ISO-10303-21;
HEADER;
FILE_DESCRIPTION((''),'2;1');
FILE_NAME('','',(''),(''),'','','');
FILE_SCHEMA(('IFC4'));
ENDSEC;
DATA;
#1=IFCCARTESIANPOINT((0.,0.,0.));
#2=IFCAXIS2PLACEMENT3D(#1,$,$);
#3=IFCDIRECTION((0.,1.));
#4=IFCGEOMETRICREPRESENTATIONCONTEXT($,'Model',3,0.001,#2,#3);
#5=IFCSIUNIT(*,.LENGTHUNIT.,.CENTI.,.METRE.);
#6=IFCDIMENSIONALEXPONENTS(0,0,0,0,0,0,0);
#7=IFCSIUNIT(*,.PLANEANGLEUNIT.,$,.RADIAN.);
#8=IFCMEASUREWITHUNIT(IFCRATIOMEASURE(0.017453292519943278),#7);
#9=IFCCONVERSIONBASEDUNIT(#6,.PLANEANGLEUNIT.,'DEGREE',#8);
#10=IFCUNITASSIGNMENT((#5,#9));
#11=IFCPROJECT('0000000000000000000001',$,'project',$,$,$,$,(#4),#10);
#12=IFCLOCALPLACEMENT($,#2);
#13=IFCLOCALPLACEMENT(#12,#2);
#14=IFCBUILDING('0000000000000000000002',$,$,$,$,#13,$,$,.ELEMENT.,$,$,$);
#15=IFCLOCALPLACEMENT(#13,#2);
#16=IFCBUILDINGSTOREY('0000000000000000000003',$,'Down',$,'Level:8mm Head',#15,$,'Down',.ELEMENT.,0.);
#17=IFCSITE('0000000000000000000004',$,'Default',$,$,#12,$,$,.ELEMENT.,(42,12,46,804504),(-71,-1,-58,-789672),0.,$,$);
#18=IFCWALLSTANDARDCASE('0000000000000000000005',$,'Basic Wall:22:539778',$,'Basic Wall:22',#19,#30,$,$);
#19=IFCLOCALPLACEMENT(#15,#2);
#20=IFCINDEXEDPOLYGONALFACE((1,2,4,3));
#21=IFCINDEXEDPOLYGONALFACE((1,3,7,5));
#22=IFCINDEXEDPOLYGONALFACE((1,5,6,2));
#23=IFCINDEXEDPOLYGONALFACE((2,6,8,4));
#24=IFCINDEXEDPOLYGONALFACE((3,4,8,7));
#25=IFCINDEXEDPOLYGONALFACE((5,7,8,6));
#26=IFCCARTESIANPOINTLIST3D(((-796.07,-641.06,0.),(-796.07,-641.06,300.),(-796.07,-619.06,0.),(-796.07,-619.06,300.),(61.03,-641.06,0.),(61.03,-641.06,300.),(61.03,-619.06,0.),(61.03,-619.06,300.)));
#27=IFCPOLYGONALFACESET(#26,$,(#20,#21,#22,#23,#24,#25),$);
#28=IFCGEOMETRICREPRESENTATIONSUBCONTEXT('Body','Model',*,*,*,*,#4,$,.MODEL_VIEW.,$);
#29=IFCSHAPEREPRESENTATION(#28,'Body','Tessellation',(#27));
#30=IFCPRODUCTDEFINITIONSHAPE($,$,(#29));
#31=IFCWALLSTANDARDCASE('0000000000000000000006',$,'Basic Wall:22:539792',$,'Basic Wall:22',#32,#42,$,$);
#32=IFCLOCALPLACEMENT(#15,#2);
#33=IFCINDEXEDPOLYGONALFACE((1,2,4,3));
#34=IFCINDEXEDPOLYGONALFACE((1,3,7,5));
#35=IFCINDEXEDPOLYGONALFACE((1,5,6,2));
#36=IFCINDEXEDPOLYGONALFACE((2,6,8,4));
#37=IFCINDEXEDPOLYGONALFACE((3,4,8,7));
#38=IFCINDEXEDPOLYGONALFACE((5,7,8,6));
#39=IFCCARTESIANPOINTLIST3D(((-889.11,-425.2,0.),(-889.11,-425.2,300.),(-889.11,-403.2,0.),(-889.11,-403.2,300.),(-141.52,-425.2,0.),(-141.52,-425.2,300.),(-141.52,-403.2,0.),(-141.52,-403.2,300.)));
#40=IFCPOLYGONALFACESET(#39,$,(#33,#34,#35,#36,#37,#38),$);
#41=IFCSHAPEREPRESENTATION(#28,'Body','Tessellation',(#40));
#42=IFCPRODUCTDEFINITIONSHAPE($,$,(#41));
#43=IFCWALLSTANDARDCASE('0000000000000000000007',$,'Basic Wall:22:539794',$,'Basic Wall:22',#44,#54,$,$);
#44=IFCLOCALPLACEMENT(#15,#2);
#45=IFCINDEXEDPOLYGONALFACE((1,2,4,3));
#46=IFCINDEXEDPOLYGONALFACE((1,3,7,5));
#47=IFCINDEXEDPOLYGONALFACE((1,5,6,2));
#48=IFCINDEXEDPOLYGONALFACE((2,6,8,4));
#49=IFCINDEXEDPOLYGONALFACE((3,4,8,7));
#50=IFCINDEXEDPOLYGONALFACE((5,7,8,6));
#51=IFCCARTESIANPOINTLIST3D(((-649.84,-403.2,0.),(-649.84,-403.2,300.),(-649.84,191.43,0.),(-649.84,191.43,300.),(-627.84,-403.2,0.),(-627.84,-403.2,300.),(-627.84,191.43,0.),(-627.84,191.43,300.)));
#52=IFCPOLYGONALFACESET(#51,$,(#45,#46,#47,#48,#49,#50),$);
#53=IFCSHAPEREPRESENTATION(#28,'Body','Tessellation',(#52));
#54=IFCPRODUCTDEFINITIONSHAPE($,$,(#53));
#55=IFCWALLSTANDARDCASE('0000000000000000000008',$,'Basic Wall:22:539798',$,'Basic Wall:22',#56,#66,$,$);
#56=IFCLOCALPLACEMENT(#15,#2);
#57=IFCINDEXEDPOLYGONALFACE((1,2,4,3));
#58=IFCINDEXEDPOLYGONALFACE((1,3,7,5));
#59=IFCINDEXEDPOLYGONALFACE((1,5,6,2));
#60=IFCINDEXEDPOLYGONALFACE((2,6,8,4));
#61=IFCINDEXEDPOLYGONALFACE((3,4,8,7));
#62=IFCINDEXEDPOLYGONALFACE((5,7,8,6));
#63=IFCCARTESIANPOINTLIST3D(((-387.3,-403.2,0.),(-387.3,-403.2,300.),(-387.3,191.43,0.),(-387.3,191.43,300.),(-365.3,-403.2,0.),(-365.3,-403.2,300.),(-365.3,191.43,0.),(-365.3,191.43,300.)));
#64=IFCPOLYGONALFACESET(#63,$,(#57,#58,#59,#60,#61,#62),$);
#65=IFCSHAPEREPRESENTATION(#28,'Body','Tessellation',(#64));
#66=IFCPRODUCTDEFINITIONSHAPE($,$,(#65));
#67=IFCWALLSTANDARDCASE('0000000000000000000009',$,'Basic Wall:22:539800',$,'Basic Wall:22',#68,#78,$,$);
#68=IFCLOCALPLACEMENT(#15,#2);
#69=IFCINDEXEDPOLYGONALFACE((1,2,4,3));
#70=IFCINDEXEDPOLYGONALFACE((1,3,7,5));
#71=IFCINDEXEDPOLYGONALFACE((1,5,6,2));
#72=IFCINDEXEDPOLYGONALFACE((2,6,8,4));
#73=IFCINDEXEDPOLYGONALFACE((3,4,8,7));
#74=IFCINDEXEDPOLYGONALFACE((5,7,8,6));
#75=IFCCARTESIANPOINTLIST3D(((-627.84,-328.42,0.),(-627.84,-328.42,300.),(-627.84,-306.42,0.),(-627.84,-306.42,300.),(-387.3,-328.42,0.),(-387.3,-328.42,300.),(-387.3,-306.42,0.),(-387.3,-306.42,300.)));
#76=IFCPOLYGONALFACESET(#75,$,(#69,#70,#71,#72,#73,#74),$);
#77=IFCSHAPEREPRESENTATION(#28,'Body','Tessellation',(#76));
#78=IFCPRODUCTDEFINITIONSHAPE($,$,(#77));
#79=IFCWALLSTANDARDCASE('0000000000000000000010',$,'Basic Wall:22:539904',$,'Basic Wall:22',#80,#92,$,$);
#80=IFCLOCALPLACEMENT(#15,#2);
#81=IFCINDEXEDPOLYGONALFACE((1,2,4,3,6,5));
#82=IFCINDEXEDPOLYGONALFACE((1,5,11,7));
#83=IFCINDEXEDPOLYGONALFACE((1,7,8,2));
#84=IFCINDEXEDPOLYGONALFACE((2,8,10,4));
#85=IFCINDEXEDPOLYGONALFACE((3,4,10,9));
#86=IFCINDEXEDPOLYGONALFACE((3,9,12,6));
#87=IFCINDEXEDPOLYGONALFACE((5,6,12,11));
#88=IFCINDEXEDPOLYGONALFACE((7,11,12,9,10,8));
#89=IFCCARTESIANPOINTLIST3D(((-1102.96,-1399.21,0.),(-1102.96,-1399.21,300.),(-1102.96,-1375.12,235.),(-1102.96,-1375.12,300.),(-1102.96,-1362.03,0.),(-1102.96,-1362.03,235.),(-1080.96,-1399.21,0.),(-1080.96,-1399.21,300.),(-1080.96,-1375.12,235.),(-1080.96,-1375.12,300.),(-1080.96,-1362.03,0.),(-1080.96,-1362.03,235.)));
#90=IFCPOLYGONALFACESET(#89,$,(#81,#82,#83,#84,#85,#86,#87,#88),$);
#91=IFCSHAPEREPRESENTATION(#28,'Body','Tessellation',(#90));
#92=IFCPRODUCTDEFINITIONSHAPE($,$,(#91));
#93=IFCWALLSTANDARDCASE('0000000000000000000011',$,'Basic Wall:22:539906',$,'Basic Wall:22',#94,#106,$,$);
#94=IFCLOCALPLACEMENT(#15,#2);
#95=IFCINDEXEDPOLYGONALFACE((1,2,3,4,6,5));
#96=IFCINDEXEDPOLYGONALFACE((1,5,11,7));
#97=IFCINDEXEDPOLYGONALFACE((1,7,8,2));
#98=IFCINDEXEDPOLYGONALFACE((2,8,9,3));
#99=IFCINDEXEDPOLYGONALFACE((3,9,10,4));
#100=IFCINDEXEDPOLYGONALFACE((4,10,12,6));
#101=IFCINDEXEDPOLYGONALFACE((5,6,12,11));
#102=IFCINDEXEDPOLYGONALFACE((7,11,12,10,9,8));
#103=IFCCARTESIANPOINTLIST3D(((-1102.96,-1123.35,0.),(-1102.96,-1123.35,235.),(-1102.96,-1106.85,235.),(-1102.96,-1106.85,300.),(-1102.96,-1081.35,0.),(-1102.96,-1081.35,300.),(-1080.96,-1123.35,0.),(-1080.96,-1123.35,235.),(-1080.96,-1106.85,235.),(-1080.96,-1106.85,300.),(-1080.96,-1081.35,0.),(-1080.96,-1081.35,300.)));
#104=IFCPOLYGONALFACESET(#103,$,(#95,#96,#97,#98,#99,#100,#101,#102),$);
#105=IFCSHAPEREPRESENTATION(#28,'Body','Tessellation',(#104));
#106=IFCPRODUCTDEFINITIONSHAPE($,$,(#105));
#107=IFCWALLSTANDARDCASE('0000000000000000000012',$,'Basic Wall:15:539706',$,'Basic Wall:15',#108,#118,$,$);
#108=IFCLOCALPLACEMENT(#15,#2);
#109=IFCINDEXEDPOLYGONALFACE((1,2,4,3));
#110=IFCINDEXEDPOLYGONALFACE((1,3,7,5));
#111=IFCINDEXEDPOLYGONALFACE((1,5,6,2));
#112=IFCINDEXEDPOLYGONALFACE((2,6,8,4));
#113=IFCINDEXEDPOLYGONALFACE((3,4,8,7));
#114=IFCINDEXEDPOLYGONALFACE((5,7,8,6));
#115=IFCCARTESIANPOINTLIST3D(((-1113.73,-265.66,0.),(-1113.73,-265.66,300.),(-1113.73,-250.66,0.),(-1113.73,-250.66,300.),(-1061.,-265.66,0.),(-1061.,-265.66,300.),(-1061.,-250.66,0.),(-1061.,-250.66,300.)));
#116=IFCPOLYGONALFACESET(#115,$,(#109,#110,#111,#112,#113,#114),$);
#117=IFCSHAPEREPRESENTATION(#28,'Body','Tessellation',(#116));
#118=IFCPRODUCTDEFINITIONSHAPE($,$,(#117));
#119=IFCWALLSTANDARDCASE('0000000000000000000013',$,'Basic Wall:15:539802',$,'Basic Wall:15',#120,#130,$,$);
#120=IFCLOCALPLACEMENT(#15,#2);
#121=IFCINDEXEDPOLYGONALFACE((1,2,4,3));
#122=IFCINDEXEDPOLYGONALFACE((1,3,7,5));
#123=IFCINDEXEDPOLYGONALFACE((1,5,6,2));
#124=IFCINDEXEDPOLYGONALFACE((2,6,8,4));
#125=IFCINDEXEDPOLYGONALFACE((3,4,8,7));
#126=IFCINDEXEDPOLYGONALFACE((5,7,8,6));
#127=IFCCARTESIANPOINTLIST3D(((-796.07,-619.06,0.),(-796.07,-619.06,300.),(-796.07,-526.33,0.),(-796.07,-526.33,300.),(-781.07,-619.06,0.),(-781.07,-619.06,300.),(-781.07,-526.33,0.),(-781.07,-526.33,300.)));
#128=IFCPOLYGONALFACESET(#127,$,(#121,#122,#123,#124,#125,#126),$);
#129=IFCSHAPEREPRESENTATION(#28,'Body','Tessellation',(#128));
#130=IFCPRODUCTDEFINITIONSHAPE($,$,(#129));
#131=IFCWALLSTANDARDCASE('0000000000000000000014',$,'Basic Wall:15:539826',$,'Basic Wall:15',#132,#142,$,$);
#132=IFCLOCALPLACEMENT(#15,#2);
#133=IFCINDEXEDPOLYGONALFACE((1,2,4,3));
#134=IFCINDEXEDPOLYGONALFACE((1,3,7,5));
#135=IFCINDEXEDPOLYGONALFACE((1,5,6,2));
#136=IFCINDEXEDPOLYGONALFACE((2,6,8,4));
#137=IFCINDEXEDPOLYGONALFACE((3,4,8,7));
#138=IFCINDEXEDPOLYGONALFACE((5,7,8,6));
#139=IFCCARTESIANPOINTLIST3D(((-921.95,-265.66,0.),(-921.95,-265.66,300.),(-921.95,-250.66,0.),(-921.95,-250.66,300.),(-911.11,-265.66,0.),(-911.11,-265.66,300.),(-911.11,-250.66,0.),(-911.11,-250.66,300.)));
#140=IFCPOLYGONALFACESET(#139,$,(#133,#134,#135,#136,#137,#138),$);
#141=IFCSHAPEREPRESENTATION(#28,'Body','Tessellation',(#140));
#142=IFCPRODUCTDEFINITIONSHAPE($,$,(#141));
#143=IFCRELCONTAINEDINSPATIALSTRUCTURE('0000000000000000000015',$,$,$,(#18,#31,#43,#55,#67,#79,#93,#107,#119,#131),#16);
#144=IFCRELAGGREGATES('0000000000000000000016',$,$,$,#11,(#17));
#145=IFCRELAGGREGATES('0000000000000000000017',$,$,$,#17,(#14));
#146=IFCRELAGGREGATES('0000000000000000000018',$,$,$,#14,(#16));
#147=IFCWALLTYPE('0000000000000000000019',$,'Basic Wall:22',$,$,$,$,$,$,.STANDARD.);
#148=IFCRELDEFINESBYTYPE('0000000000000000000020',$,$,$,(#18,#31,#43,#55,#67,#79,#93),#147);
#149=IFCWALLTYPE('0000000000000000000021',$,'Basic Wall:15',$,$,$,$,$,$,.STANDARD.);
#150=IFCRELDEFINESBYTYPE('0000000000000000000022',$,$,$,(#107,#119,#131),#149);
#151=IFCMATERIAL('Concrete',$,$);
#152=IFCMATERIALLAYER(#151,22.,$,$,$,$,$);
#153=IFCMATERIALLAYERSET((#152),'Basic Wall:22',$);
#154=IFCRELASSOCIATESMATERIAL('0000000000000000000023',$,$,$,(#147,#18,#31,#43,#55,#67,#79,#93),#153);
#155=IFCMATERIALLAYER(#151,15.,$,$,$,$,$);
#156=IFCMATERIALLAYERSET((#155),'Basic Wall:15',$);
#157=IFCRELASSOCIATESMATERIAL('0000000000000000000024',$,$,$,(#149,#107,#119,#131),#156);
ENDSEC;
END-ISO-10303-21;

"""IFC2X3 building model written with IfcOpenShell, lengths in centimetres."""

from ifc_helpers import new_model, entity, si_unit, converted_unit, direction, frame, frame_2d, origin, place, context, subcontext, project, spatial, polyline, rectangle, extrude, clip, bounded_halfspace, material, layer, layer_set, layer_usage, type_object, element, save


model = new_model("IFC2X3")

# Units and contexts
model_context = context("Model", 3, precision=0.001, world=origin(), true_north=direction((0.0, 1.0)))
body_context = subcontext(model_context, "Body", "Model", "MODEL_VIEW")
ifc_project = project(units=[si_unit("LENGTHUNIT", "METRE", prefix="CENTI"), converted_unit("PLANEANGLEUNIT", "DEGREE", entity("IfcRatioMeasure", 0.017453292519943278), si_unit("PLANEANGLEUNIT", "RADIAN"), dimensions=[0, 0, 0, 0, 0, 0, 0])], contexts=[model_context])

# Site, building, storey
site_placement = place(None, origin())
site = spatial("IfcSite", under=ifc_project, at=site_placement, Name="Default", CompositionType="ELEMENT", RefLatitude=(42, 12, 46, 804504), RefLongitude=(-71, -1, -58, -789672), RefElevation=0.0)
building_placement = place(site_placement, origin())
building = spatial("IfcBuilding", under=site, at=building_placement, CompositionType="ELEMENT")
storey_placement = place(building_placement, origin())
storey = spatial("IfcBuildingStorey", under=building, at=storey_placement, Name="Down", ObjectType="Level:8mm Head", LongName="Down", CompositionType="ELEMENT", Elevation=0.0)

# Walls
ifc_material = material(Name="Concrete")
ifc_layer_1 = layer(ifc_material, 22.0)
ifc_layer_set_1 = layer_set([ifc_layer_1], Name="Basic Wall:22")
wall_type_1 = type_object("IfcWallType", Name="Basic Wall:22", PredefinedType="STANDARD", material=ifc_layer_set_1)
ifc_layer_usage_1 = layer_usage(ifc_layer_set_1, "AXIS2", "NEGATIVE", 11.0)
wall_1_placement = place(storey_placement, frame((-796.07, -630.06, 0.0)))
element("IfcWallStandardCase", 1, at=wall_1_placement, inside=storey, type_object=wall_type_1, material=ifc_layer_usage_1, Name="Basic Wall:22:539778", ObjectType="Basic Wall:22", context=body_context, shape_type="SweptSolid", body=[
    extrude(rectangle(XDim=857.1, YDim=22.0, at=frame_2d((428.55, 0.0), x_axis=(-1.0, 0.0))), origin(), (0.0, 0.0, 1.0), 300.0),
])
ifc_layer_usage_2 = layer_usage(ifc_layer_set_1, "AXIS2", "POSITIVE", -11.0)
wall_2_placement = place(storey_placement, frame((-141.52, -414.2, 0.0), z_axis=(0.0, 0.0, 1.0), x_axis=(-1.0, 0.0, 0.0)))
element("IfcWallStandardCase", 2, at=wall_2_placement, inside=storey, type_object=wall_type_1, material=ifc_layer_usage_2, Name="Basic Wall:22:539792", ObjectType="Basic Wall:22", context=body_context, shape_type="SweptSolid", body=[
    extrude(rectangle(XDim=747.59, YDim=22.0, at=frame_2d((373.79, 0.0), x_axis=(-1.0, 0.0))), origin(), (0.0, 0.0, 1.0), 300.0),
])
ifc_layer_usage_3 = layer_usage(ifc_layer_set_1, "AXIS2", "POSITIVE", -11.0)
wall_3_placement = place(storey_placement, frame((-638.84, -403.2, 0.0), z_axis=(0.0, 0.0, 1.0), x_axis=(0.0, 1.0, 0.0)))
element("IfcWallStandardCase", 3, at=wall_3_placement, inside=storey, type_object=wall_type_1, material=ifc_layer_usage_3, Name="Basic Wall:22:539794", ObjectType="Basic Wall:22", context=body_context, shape_type="SweptSolid", body=[
    extrude(rectangle(XDim=594.63, YDim=22.0, at=frame_2d((297.31, 0.0), x_axis=(-1.0, 0.0))), origin(), (0.0, 0.0, 1.0), 300.0),
])
ifc_layer_usage_4 = layer_usage(ifc_layer_set_1, "AXIS2", "POSITIVE", -11.0)
wall_4_placement = place(storey_placement, frame((-376.3, -403.2, 0.0), z_axis=(0.0, 0.0, 1.0), x_axis=(0.0, 1.0, 0.0)))
element("IfcWallStandardCase", 4, at=wall_4_placement, inside=storey, type_object=wall_type_1, material=ifc_layer_usage_4, Name="Basic Wall:22:539798", ObjectType="Basic Wall:22", context=body_context, shape_type="SweptSolid", body=[
    extrude(rectangle(XDim=594.63, YDim=22.0, at=frame_2d((297.31, 0.0), x_axis=(-1.0, 0.0))), origin(), (0.0, 0.0, 1.0), 300.0),
])
ifc_layer_usage_5 = layer_usage(ifc_layer_set_1, "AXIS2", "NEGATIVE", 11.0)
wall_5_placement = place(storey_placement, frame((-387.3, -317.42, 0.0), z_axis=(0.0, 0.0, 1.0), x_axis=(-1.0, 0.0, 0.0)))
element("IfcWallStandardCase", 5, at=wall_5_placement, inside=storey, type_object=wall_type_1, material=ifc_layer_usage_5, Name="Basic Wall:22:539800", ObjectType="Basic Wall:22", context=body_context, shape_type="SweptSolid", body=[
    extrude(rectangle(XDim=240.54, YDim=22.0, at=frame_2d((120.27, 0.0), x_axis=(-1.0, 0.0))), origin(), (0.0, 0.0, 1.0), 300.0),
])
ifc_layer_usage_6 = layer_usage(ifc_layer_set_1, "AXIS2", "POSITIVE", -11.0)
wall_6_placement = place(storey_placement, frame((-1091.96, -1399.21, 0.0), z_axis=(0.0, 0.0, 1.0), x_axis=(0.0, 1.0, 0.0)))
element("IfcWallStandardCase", 6, at=wall_6_placement, inside=storey, type_object=wall_type_1, material=ifc_layer_usage_6, Name="Basic Wall:22:539904", ObjectType="Basic Wall:22", context=body_context, shape_type="Clipping", body=[
    clip(clip(extrude(rectangle(XDim=37.17, YDim=22.0, at=frame_2d((18.59, 0.0), x_axis=(-1.0, 0.0))), origin(), (0.0, 0.0, 1.0), 300.0), bounded_halfspace(frame((24.09, -11.0, 235.0), z_axis=(-1.0, 0.0, 0.0), x_axis=(0.0, 0.0, 1.0)), True, frame((24.09, -11.0, 235.0), z_axis=(-1.0, 0.0, 0.0), x_axis=(0.0, 0.0, 1.0)), polyline([(0.0, 0.0), (45.0, 0.0), (65.0, 0.0), (65.0, 22.0), (45.0, 22.0), (0.0, 22.0), (0.0, 0.0)]))), bounded_halfspace(frame((24.09, 11.0, 235.0), z_axis=(0.0, 0.0, 1.0), x_axis=(0.0, 1.0, 0.0)), False, frame((24.09, 11.0, 235.0), z_axis=(0.0, 0.0, 1.0), x_axis=(0.0, 1.0, 0.0)), polyline([(0.0, 0.0), (-22.0, 0.0), (-22.0, -13.09), (0.0, -13.09), (0.0, 0.0)]))),
])
ifc_layer_usage_7 = layer_usage(ifc_layer_set_1, "AXIS2", "POSITIVE", -11.0)
wall_7_placement = place(storey_placement, frame((-1091.96, -1081.35, 0.0), z_axis=(0.0, 0.0, 1.0), x_axis=(0.0, -1.0, 0.0)))
element("IfcWallStandardCase", 7, at=wall_7_placement, inside=storey, type_object=wall_type_1, material=ifc_layer_usage_7, Name="Basic Wall:22:539906", ObjectType="Basic Wall:22", context=body_context, shape_type="Clipping", body=[
    clip(clip(extrude(rectangle(XDim=42.0, YDim=22.0, at=frame_2d((21.0, 0.0), x_axis=(-1.0, 0.0))), origin(), (0.0, 0.0, 1.0), 300.0), bounded_halfspace(frame((25.5, -11.0, 235.0), z_axis=(1.0, 0.0, 0.0), x_axis=(0.0, 0.0, 1.0)), False, frame((25.5, -11.0, 235.0), z_axis=(1.0, 0.0, 0.0), x_axis=(0.0, 0.0, 1.0)), polyline([(0.0, 0.0), (0.0, -22.0), (45.0, -22.0), (65.0, -22.0), (65.0, 0.0), (45.0, 0.0), (0.0, 0.0)]))), bounded_halfspace(frame((25.5, 11.0, 235.0), z_axis=(0.0, 0.0, 1.0), x_axis=(0.0, -1.0, 0.0)), False, frame((25.5, 11.0, 235.0), z_axis=(0.0, 0.0, 1.0), x_axis=(0.0, -1.0, 0.0)), polyline([(0.0, 0.0), (22.0, 0.0), (22.0, 16.5), (0.0, 16.5), (0.0, 0.0)]))),
])
ifc_layer_2 = layer(ifc_material, 15.0)
ifc_layer_set_2 = layer_set([ifc_layer_2], Name="Basic Wall:15")
ifc_layer_usage_8 = layer_usage(ifc_layer_set_2, "AXIS2", "NEGATIVE", 7.5)
wall_type_2 = type_object("IfcWallType", Name="Basic Wall:15", PredefinedType="STANDARD", material=ifc_layer_set_2)
wall_8_placement = place(storey_placement, frame((-1113.73, -258.16, 0.0)))
element("IfcWallStandardCase", 8, at=wall_8_placement, inside=storey, type_object=wall_type_2, material=ifc_layer_usage_8, Name="Basic Wall:15:539706", ObjectType="Basic Wall:15", context=body_context, shape_type="SweptSolid", body=[
    extrude(rectangle(XDim=52.73, YDim=15.0, at=frame_2d((26.37, 0.0), x_axis=(-1.0, 0.0))), origin(), (0.0, 0.0, 1.0), 300.0),
])
ifc_layer_usage_9 = layer_usage(ifc_layer_set_2, "AXIS2", "NEGATIVE", 7.5)
wall_9_placement = place(storey_placement, frame((-788.57, -526.33, 0.0), z_axis=(0.0, 0.0, 1.0), x_axis=(0.0, -1.0, 0.0)))
element("IfcWallStandardCase", 9, at=wall_9_placement, inside=storey, type_object=wall_type_2, material=ifc_layer_usage_9, Name="Basic Wall:15:539802", ObjectType="Basic Wall:15", context=body_context, shape_type="SweptSolid", body=[
    extrude(rectangle(XDim=92.73, YDim=15.0, at=frame_2d((46.36, 0.0), x_axis=(-1.0, 0.0))), origin(), (0.0, 0.0, 1.0), 300.0),
])
ifc_layer_usage_10 = layer_usage(ifc_layer_set_2, "AXIS2", "NEGATIVE", 7.5)
wall_10_placement = place(storey_placement, frame((-921.95, -258.16, 0.0)))
element("IfcWallStandardCase", 10, at=wall_10_placement, inside=storey, type_object=wall_type_2, material=ifc_layer_usage_10, Name="Basic Wall:15:539826", ObjectType="Basic Wall:15", context=body_context, shape_type="SweptSolid", body=[
    extrude(rectangle(XDim=10.85, YDim=15.0, at=frame_2d((5.42, 0.0), x_axis=(-1.0, 0.0))), origin(), (0.0, 0.0, 1.0), 300.0),
])

save(model, "model.ifc")
